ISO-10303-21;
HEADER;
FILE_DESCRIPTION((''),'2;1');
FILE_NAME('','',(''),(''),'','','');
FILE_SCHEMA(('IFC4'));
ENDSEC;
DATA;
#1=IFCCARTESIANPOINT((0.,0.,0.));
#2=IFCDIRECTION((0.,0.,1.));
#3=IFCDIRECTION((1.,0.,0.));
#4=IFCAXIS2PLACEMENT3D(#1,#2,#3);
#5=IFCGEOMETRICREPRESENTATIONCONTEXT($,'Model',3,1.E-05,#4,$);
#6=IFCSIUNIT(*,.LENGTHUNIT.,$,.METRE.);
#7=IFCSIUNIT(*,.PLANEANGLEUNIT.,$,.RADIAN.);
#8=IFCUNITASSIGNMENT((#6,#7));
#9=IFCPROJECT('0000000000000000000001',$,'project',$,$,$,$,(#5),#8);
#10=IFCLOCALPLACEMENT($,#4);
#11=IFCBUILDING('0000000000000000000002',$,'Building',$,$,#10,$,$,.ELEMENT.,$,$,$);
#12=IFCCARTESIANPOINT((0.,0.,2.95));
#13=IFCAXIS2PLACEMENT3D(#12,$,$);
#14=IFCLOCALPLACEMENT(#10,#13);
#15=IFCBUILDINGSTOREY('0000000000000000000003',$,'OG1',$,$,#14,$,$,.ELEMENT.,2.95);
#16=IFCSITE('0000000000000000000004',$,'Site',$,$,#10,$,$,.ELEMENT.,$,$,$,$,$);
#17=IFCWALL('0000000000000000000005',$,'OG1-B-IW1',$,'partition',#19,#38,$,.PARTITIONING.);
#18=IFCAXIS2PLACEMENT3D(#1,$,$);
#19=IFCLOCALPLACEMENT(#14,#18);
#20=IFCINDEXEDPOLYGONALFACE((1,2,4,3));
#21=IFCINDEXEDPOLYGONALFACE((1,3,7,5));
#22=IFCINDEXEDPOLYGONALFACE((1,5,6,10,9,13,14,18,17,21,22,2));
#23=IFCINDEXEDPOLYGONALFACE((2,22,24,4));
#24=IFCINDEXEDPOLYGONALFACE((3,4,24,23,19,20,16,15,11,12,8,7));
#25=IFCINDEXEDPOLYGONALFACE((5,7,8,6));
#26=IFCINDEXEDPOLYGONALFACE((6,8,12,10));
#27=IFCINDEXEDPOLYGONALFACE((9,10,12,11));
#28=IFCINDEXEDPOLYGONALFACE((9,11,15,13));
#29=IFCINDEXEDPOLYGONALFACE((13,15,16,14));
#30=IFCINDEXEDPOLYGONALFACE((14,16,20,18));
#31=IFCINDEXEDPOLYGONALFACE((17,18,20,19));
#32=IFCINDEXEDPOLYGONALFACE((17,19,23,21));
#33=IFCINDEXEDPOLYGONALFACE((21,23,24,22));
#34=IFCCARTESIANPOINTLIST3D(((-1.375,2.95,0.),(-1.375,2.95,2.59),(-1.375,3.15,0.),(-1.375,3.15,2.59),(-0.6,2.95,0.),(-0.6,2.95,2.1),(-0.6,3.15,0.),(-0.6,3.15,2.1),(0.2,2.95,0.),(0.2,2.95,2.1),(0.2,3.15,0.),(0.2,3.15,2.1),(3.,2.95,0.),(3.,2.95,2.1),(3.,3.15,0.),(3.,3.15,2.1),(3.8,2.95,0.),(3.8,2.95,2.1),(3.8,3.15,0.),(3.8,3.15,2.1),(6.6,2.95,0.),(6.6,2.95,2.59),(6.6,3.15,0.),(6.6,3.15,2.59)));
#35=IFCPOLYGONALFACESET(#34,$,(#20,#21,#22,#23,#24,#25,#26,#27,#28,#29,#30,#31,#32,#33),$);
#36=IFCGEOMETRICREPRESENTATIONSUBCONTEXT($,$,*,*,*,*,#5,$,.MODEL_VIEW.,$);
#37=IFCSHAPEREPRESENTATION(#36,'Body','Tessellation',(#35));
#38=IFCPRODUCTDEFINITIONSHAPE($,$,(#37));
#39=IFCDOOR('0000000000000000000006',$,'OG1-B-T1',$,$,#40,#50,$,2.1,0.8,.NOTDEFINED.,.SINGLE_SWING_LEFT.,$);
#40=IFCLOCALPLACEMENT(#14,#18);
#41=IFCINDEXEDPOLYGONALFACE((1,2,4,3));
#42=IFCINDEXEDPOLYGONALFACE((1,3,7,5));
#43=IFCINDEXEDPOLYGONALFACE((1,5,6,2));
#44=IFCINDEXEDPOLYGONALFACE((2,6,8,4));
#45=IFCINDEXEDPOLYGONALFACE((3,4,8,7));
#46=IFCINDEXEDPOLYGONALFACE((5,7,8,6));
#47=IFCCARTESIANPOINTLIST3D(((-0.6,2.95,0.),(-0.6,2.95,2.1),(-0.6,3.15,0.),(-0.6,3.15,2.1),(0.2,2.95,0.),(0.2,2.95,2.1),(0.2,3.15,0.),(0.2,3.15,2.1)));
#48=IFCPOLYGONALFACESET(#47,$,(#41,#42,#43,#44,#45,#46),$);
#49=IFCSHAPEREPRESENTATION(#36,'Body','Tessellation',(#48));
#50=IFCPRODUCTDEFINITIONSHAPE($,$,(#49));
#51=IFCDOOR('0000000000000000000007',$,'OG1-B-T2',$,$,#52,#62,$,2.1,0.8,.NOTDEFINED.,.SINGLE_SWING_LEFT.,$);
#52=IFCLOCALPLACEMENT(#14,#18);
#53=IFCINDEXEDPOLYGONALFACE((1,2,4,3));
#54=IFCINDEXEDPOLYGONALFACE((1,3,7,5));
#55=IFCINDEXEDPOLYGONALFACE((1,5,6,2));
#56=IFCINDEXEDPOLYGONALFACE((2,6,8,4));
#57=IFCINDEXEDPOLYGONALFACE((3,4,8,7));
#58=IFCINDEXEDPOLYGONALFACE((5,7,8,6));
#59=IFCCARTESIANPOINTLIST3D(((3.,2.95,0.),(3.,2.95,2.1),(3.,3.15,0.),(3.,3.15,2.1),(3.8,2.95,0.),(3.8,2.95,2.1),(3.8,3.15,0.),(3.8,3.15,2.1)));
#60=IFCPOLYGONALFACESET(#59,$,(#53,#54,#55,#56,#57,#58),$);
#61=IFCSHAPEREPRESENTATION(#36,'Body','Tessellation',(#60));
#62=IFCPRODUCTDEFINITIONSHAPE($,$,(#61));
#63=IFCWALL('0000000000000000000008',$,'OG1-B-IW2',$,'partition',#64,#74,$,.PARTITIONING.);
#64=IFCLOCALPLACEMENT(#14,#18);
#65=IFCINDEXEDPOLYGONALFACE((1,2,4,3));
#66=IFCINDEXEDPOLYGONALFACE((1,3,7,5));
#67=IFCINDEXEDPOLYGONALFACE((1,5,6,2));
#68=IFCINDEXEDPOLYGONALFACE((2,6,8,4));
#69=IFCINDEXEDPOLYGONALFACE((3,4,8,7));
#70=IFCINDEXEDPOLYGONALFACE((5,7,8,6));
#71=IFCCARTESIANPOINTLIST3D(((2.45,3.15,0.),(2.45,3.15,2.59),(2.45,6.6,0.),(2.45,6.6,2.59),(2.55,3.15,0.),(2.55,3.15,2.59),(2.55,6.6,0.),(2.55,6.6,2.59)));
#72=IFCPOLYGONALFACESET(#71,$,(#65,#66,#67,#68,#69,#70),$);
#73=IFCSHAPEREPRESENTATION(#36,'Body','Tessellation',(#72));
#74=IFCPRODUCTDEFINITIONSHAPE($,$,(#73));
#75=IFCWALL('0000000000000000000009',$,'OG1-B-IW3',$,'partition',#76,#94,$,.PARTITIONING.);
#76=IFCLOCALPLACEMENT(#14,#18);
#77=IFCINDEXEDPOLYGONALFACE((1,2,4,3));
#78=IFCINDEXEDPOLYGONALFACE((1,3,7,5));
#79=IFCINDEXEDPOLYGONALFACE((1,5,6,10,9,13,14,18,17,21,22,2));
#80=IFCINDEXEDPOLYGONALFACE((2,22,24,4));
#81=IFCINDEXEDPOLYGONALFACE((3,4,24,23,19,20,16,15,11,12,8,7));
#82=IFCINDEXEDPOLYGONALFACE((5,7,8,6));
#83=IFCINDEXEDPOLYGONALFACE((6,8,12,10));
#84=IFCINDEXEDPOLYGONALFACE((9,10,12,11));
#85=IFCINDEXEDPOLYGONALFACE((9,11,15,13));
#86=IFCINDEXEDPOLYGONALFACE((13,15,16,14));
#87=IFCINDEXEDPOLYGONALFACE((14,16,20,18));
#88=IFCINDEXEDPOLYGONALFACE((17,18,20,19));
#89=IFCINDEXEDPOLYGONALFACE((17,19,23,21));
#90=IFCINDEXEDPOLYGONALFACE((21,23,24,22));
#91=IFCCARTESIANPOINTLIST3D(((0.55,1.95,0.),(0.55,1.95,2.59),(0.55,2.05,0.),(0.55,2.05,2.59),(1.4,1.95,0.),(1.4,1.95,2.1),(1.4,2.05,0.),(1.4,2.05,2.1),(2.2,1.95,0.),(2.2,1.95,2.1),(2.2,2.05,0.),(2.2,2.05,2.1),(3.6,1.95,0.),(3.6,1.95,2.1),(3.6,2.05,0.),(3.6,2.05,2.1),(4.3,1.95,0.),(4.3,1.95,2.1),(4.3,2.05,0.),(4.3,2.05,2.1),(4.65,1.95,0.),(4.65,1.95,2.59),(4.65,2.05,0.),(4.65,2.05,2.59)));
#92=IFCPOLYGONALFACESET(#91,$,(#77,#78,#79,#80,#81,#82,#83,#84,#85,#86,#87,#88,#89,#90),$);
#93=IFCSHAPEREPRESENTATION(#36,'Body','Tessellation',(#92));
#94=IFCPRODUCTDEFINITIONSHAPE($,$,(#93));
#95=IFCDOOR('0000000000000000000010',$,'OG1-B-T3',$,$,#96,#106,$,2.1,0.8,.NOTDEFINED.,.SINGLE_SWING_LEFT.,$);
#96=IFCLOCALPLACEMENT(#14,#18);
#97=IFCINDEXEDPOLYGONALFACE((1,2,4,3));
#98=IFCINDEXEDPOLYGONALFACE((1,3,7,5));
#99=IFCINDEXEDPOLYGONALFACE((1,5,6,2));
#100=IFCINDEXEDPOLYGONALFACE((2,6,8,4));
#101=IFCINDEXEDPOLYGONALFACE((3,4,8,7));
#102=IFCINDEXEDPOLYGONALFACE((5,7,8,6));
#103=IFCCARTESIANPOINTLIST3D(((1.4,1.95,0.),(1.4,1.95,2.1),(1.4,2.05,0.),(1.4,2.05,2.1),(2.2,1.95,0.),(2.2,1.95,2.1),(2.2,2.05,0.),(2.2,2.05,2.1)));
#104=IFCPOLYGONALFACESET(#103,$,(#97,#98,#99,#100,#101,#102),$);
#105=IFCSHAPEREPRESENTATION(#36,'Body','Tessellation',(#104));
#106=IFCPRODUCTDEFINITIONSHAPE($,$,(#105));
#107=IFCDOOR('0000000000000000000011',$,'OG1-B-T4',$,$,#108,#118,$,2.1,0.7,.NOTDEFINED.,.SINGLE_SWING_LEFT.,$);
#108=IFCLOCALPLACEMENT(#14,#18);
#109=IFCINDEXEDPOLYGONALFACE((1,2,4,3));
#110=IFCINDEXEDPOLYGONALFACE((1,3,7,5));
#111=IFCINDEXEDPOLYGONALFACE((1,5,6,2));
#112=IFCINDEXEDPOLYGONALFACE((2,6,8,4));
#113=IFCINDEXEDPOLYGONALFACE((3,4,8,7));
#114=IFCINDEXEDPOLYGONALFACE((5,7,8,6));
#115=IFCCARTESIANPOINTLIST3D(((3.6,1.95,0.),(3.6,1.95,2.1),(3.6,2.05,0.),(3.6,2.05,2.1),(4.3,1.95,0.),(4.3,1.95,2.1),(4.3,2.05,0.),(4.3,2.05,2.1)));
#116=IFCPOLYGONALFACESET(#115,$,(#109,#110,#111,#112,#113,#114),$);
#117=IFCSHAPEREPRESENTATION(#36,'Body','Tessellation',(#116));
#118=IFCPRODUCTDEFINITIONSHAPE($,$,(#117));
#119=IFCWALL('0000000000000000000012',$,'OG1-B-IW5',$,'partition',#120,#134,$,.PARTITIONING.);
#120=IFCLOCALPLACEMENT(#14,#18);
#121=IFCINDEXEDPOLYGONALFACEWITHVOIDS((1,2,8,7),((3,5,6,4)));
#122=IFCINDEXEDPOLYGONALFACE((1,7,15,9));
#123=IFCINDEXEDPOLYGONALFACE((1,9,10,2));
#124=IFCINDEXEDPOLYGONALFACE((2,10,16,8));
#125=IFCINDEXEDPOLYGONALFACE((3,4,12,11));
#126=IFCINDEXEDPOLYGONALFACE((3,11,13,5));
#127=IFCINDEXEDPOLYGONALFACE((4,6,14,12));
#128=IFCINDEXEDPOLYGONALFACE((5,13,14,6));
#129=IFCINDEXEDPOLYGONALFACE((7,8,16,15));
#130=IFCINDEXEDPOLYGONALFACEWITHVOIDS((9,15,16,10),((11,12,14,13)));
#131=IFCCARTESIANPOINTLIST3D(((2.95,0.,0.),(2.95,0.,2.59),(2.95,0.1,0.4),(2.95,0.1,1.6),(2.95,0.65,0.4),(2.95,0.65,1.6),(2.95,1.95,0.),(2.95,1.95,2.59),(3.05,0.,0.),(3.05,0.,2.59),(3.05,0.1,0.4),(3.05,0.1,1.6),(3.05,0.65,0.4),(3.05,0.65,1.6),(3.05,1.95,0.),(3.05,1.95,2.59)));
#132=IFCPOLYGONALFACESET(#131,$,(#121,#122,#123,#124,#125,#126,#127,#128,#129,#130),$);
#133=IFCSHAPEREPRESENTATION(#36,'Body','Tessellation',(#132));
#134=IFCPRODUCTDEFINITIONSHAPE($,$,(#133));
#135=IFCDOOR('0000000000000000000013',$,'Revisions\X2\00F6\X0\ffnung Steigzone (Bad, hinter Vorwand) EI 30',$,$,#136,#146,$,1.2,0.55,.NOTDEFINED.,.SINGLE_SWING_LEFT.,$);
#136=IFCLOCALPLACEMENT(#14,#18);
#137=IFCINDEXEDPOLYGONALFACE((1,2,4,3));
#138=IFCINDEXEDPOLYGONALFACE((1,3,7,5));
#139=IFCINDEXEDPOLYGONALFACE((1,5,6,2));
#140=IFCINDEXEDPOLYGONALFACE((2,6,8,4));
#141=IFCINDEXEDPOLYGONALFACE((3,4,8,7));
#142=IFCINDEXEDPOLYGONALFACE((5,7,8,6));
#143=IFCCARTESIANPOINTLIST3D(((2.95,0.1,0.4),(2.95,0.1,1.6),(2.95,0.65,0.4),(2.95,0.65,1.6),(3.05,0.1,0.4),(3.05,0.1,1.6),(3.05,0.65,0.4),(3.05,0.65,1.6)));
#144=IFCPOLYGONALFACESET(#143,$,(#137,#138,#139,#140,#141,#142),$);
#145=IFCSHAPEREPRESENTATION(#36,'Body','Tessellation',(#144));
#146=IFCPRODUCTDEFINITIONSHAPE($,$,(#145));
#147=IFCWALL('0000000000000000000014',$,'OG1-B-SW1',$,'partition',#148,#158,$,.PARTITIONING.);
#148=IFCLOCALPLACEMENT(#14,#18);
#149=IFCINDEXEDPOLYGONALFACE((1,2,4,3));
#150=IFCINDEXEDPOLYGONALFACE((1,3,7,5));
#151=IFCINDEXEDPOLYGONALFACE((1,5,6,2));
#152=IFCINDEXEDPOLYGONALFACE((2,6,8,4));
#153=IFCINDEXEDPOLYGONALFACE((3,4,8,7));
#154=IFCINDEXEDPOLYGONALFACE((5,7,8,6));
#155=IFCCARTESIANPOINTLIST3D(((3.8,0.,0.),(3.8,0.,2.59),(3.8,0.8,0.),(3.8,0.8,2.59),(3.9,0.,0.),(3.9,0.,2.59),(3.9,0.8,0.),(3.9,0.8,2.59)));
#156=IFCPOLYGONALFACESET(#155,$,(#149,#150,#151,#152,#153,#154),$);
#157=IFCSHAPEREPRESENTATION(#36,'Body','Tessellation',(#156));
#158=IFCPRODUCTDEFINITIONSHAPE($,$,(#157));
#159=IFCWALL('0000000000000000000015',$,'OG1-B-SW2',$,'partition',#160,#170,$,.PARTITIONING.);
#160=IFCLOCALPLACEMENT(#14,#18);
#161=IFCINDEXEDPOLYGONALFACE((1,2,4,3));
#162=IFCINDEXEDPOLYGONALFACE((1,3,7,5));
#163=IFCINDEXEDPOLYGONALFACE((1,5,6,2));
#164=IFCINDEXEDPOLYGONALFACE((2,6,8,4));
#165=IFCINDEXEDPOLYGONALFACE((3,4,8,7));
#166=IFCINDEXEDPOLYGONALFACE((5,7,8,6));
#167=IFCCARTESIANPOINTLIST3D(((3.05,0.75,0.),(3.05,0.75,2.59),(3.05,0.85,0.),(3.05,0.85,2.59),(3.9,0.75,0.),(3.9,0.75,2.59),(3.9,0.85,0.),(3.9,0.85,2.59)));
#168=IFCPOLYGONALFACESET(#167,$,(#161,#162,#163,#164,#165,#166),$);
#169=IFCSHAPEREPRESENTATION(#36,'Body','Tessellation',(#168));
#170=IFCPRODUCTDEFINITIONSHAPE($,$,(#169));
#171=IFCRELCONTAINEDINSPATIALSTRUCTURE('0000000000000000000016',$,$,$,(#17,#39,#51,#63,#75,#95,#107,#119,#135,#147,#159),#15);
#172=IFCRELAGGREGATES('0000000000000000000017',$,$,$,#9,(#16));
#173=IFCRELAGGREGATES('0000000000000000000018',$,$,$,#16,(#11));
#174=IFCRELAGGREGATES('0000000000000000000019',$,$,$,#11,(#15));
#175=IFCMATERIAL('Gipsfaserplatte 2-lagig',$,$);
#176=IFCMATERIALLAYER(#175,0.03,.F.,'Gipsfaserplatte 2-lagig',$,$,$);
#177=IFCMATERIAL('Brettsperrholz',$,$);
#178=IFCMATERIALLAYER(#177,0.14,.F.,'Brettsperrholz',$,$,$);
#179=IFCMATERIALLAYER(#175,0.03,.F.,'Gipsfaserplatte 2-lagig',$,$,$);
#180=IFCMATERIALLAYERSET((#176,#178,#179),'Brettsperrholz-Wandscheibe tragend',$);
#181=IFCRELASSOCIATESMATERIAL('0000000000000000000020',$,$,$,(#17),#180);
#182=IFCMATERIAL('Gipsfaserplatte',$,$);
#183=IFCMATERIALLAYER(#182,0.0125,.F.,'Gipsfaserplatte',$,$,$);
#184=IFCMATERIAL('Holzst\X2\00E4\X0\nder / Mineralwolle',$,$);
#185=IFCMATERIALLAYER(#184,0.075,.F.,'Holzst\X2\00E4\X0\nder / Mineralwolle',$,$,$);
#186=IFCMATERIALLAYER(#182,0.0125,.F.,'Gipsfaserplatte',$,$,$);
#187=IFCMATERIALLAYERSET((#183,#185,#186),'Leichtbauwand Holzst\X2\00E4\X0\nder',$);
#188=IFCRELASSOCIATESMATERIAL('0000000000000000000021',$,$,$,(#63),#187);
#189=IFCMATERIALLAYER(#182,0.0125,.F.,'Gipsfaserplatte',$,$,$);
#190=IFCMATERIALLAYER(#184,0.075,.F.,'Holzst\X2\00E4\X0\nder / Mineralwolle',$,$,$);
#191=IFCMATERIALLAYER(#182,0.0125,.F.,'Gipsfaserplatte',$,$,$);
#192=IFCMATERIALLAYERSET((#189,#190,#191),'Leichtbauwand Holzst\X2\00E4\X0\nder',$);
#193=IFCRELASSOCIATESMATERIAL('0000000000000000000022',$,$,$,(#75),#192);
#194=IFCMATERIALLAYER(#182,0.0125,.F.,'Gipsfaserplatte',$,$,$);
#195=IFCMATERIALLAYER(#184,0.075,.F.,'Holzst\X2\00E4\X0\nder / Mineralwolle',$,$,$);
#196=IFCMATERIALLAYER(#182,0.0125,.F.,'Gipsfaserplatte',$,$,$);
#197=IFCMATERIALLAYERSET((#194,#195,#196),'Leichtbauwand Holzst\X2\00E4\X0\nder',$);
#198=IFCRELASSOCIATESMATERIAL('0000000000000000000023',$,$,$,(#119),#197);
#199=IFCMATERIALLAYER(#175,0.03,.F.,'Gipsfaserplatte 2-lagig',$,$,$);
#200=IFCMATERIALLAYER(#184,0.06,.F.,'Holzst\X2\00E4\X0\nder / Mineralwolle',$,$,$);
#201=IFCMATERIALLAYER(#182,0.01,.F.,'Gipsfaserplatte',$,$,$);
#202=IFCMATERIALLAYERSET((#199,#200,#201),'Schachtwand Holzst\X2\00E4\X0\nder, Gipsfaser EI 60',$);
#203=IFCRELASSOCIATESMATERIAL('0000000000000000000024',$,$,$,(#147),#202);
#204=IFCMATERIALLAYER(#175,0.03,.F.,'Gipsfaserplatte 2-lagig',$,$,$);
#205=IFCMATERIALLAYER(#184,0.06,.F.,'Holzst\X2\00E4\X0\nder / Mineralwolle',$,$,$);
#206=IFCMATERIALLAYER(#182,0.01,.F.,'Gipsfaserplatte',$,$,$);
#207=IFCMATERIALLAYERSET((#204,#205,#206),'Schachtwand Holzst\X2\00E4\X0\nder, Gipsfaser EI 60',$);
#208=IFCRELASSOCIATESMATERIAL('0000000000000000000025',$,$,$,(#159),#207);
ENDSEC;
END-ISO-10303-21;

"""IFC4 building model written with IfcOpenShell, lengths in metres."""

from ifc_helpers import new_model, si_unit, frame, frame_2d, origin, origin_with_axes, place, context, subcontext, project, spatial, rectangle, extrude, material, layer, layer_set, element, fill, save


model = new_model("IFC4")

# Units and contexts
model_context = context("Model", 3, precision=1e-05, world=origin_with_axes())
sub_context = subcontext(model_context, None, None, "MODEL_VIEW")
ifc_project = project(units=[si_unit("LENGTHUNIT", "METRE"), si_unit("PLANEANGLEUNIT", "RADIAN")], contexts=[model_context])

# Site, building, storey
placement = place(None, origin_with_axes())
site = spatial("IfcSite", under=ifc_project, at=placement, Name="Site", CompositionType="ELEMENT")
building = spatial("IfcBuilding", under=site, at=placement, Name="Building", CompositionType="ELEMENT")
storey_placement = place(placement, frame((0.0, 0.0, 2.95)))
storey = spatial("IfcBuildingStorey", under=building, at=storey_placement, Name="OG1", CompositionType="ELEMENT", Elevation=2.95)

# Shared definitions
ifc_material_1 = material(Name="Gipsfaserplatte")

# Wall, openings, doors
ifc_material_2 = material(Name="Gipsfaserplatte 2-lagig")
ifc_layer_1 = layer(ifc_material_2, 0.03, ventilated=False, Name="Gipsfaserplatte 2-lagig")
ifc_material_3 = material(Name="Brettsperrholz")
ifc_layer_2 = layer(ifc_material_3, 0.14, ventilated=False, Name="Brettsperrholz")
ifc_layer_3 = layer(ifc_material_2, 0.03, ventilated=False, Name="Gipsfaserplatte 2-lagig")
ifc_layer_set_1 = layer_set([ifc_layer_1, ifc_layer_2, ifc_layer_3], Name="Brettsperrholz-Wandscheibe tragend")
wall_1_placement = place(storey_placement, frame((-1.375, 3.05, 0.0), z_axis=(0.0, 0.0, 1.0), x_axis=(1.0, 0.0, 0.0)))
wall_1 = element("IfcWall", 1, at=wall_1_placement, inside=storey, material=ifc_layer_set_1, Name="OG1-B-IW1", ObjectType="partition", PredefinedType="PARTITIONING", context=sub_context, shape_type="SweptSolid", body=[
    extrude(rectangle(XDim=7.975, YDim=0.2, at=frame_2d((3.9875, 0.0))), origin(), (0.0, 0.0, 1.0), 2.59),
])
opening_1_placement = place(wall_1_placement, frame((1.175, 0.15, 0.0), z_axis=(0.0, -1.0, 0.0), x_axis=(1.0, 0.0, 0.0)))
opening_1 = element("IfcOpeningElement", 2, at=opening_1_placement, cuts=wall_1, PredefinedType="OPENING", context=sub_context, shape_type="SweptSolid", body=[
    extrude(rectangle(XDim=0.8, YDim=2.1, at=frame_2d((0.0, 1.05))), origin(), (0.0, 0.0, 1.0), 0.3),
])
opening_2_placement = place(wall_1_placement, frame((4.775, 0.15, 0.0), z_axis=(0.0, -1.0, 0.0), x_axis=(1.0, 0.0, 0.0)))
opening_2 = element("IfcOpeningElement", 3, at=opening_2_placement, cuts=wall_1, PredefinedType="OPENING", context=sub_context, shape_type="SweptSolid", body=[
    extrude(rectangle(XDim=0.8, YDim=2.1, at=frame_2d((0.0, 1.05))), origin(), (0.0, 0.0, 1.0), 0.3),
])
door_1_placement = place(wall_1_placement, frame((1.175, 0.1, 0.0), z_axis=(0.0, -1.0, 0.0), x_axis=(1.0, 0.0, 0.0)))
door_1 = element("IfcDoor", 4, at=door_1_placement, inside=storey, Name="OG1-B-T1", OperationType="SINGLE_SWING_LEFT", OverallHeight=2.1, OverallWidth=0.8, PredefinedType="NOTDEFINED", context=sub_context, shape_type="SweptSolid", body=[
    extrude(rectangle(XDim=0.8, YDim=2.1, at=frame_2d((0.0, 1.05))), origin(), (0.0, 0.0, 1.0), 0.2),
])
fill(opening_1, door_1)
door_2_placement = place(wall_1_placement, frame((4.775, 0.1, 0.0), z_axis=(0.0, -1.0, 0.0), x_axis=(1.0, 0.0, 0.0)))
door_2 = element("IfcDoor", 5, at=door_2_placement, inside=storey, Name="OG1-B-T2", OperationType="SINGLE_SWING_LEFT", OverallHeight=2.1, OverallWidth=0.8, PredefinedType="NOTDEFINED", context=sub_context, shape_type="SweptSolid", body=[
    extrude(rectangle(XDim=0.8, YDim=2.1, at=frame_2d((0.0, 1.05))), origin(), (0.0, 0.0, 1.0), 0.2),
])
fill(opening_2, door_2)

# Wall
ifc_layer_4 = layer(ifc_material_1, 0.0125, ventilated=False, Name="Gipsfaserplatte")
ifc_material_4 = material(Name="Holzständer / Mineralwolle")
ifc_layer_5 = layer(ifc_material_4, 0.075, ventilated=False, Name="Holzständer / Mineralwolle")
ifc_layer_6 = layer(ifc_material_1, 0.0125, ventilated=False, Name="Gipsfaserplatte")
ifc_layer_set_2 = layer_set([ifc_layer_4, ifc_layer_5, ifc_layer_6], Name="Leichtbauwand Holzständer")
wall_2_placement = place(storey_placement, frame((2.5, 3.15, 0.0), z_axis=(0.0, 0.0, 1.0), x_axis=(0.0, 1.0, 0.0)))
element("IfcWall", 6, at=wall_2_placement, inside=storey, material=ifc_layer_set_2, Name="OG1-B-IW2", ObjectType="partition", PredefinedType="PARTITIONING", context=sub_context, shape_type="SweptSolid", body=[
    extrude(rectangle(XDim=3.45, YDim=0.1, at=frame_2d((1.725, 0.0))), origin(), (0.0, 0.0, 1.0), 2.59),
])

# Wall, openings, doors
ifc_layer_7 = layer(ifc_material_1, 0.0125, ventilated=False, Name="Gipsfaserplatte")
ifc_layer_8 = layer(ifc_material_4, 0.075, ventilated=False, Name="Holzständer / Mineralwolle")
ifc_layer_9 = layer(ifc_material_1, 0.0125, ventilated=False, Name="Gipsfaserplatte")
ifc_layer_set_3 = layer_set([ifc_layer_7, ifc_layer_8, ifc_layer_9], Name="Leichtbauwand Holzständer")
wall_3_placement = place(storey_placement, frame((0.55, 2.0, 0.0), z_axis=(0.0, 0.0, 1.0), x_axis=(1.0, 0.0, 0.0)))
wall_3 = element("IfcWall", 7, at=wall_3_placement, inside=storey, material=ifc_layer_set_3, Name="OG1-B-IW3", ObjectType="partition", PredefinedType="PARTITIONING", context=sub_context, shape_type="SweptSolid", body=[
    extrude(rectangle(XDim=4.1, YDim=0.1, at=frame_2d((2.05, 0.0))), origin(), (0.0, 0.0, 1.0), 2.59),
])
opening_3_placement = place(wall_3_placement, frame((1.25, 0.1, 0.0), z_axis=(0.0, -1.0, 0.0), x_axis=(1.0, 0.0, 0.0)))
opening_3 = element("IfcOpeningElement", 8, at=opening_3_placement, cuts=wall_3, PredefinedType="OPENING", context=sub_context, shape_type="SweptSolid", body=[
    extrude(rectangle(XDim=0.8, YDim=2.1, at=frame_2d((0.0, 1.05))), origin(), (0.0, 0.0, 1.0), 0.2),
])
opening_4_placement = place(wall_3_placement, frame((3.4, 0.1, 0.0), z_axis=(0.0, -1.0, 0.0), x_axis=(1.0, 0.0, 0.0)))
opening_4 = element("IfcOpeningElement", 9, at=opening_4_placement, cuts=wall_3, PredefinedType="OPENING", context=sub_context, shape_type="SweptSolid", body=[
    extrude(rectangle(XDim=0.7, YDim=2.1, at=frame_2d((0.0, 1.05))), origin(), (0.0, 0.0, 1.0), 0.2),
])
door_3_placement = place(wall_3_placement, frame((1.25, 0.05, 0.0), z_axis=(0.0, -1.0, 0.0), x_axis=(1.0, 0.0, 0.0)))
door_3 = element("IfcDoor", 10, at=door_3_placement, inside=storey, Name="OG1-B-T3", OperationType="SINGLE_SWING_LEFT", OverallHeight=2.1, OverallWidth=0.8, PredefinedType="NOTDEFINED", context=sub_context, shape_type="SweptSolid", body=[
    extrude(rectangle(XDim=0.8, YDim=2.1, at=frame_2d((0.0, 1.05))), origin(), (0.0, 0.0, 1.0), 0.1),
])
fill(opening_3, door_3)
door_4_placement = place(wall_3_placement, frame((3.4, 0.05, 0.0), z_axis=(0.0, -1.0, 0.0), x_axis=(1.0, 0.0, 0.0)))
door_4 = element("IfcDoor", 11, at=door_4_placement, inside=storey, Name="OG1-B-T4", OperationType="SINGLE_SWING_LEFT", OverallHeight=2.1, OverallWidth=0.7, PredefinedType="NOTDEFINED", context=sub_context, shape_type="SweptSolid", body=[
    extrude(rectangle(XDim=0.7, YDim=2.1, at=frame_2d((0.0, 1.05))), origin(), (0.0, 0.0, 1.0), 0.1),
])
fill(opening_4, door_4)

# Wall, opening, door
ifc_layer_10 = layer(ifc_material_1, 0.0125, ventilated=False, Name="Gipsfaserplatte")
ifc_layer_11 = layer(ifc_material_4, 0.075, ventilated=False, Name="Holzständer / Mineralwolle")
ifc_layer_12 = layer(ifc_material_1, 0.0125, ventilated=False, Name="Gipsfaserplatte")
ifc_layer_set_4 = layer_set([ifc_layer_10, ifc_layer_11, ifc_layer_12], Name="Leichtbauwand Holzständer")
wall_4_placement = place(storey_placement, frame((3.0, 0.0, 0.0), z_axis=(0.0, 0.0, 1.0), x_axis=(0.0, 1.0, 0.0)))
wall_4 = element("IfcWall", 12, at=wall_4_placement, inside=storey, material=ifc_layer_set_4, Name="OG1-B-IW5", ObjectType="partition", PredefinedType="PARTITIONING", context=sub_context, shape_type="SweptSolid", body=[
    extrude(rectangle(XDim=1.95, YDim=0.1, at=frame_2d((0.975, 0.0))), origin(), (0.0, 0.0, 1.0), 2.59),
])
opening_5_placement = place(wall_4_placement, frame((0.375, 0.1, 0.4), z_axis=(0.0, -1.0, 0.0), x_axis=(1.0, 0.0, 0.0)))
opening_5 = element("IfcOpeningElement", 13, at=opening_5_placement, cuts=wall_4, PredefinedType="OPENING", context=sub_context, shape_type="SweptSolid", body=[
    extrude(rectangle(XDim=0.55, YDim=1.2, at=frame_2d((0.0, 0.6))), origin(), (0.0, 0.0, 1.0), 0.2),
])
door_5_placement = place(wall_4_placement, frame((0.375, 0.05, 0.4), z_axis=(0.0, -1.0, 0.0), x_axis=(1.0, 0.0, 0.0)))
door_5 = element("IfcDoor", 14, at=door_5_placement, inside=storey, Name="Revisionsöffnung Steigzone (Bad, hinter Vorwand) EI 30", OperationType="SINGLE_SWING_LEFT", OverallHeight=1.2, OverallWidth=0.55, PredefinedType="NOTDEFINED", context=sub_context, shape_type="SweptSolid", body=[
    extrude(rectangle(XDim=0.55, YDim=1.2, at=frame_2d((0.0, 0.6))), origin(), (0.0, 0.0, 1.0), 0.1),
])
fill(opening_5, door_5)

# Walls
ifc_layer_13 = layer(ifc_material_2, 0.03, ventilated=False, Name="Gipsfaserplatte 2-lagig")
ifc_layer_14 = layer(ifc_material_4, 0.06, ventilated=False, Name="Holzständer / Mineralwolle")
ifc_layer_15 = layer(ifc_material_1, 0.01, ventilated=False, Name="Gipsfaserplatte")
ifc_layer_set_5 = layer_set([ifc_layer_13, ifc_layer_14, ifc_layer_15], Name="Schachtwand Holzständer, Gipsfaser EI 60")
wall_5_placement = place(storey_placement, frame((3.85, 0.0, 0.0), z_axis=(0.0, 0.0, 1.0), x_axis=(0.0, 1.0, 0.0)))
element("IfcWall", 15, at=wall_5_placement, inside=storey, material=ifc_layer_set_5, Name="OG1-B-SW1", ObjectType="partition", PredefinedType="PARTITIONING", context=sub_context, shape_type="SweptSolid", body=[
    extrude(rectangle(XDim=0.8, YDim=0.1, at=frame_2d((0.4, 0.0))), origin(), (0.0, 0.0, 1.0), 2.59),
])
ifc_layer_16 = layer(ifc_material_2, 0.03, ventilated=False, Name="Gipsfaserplatte 2-lagig")
ifc_layer_17 = layer(ifc_material_4, 0.06, ventilated=False, Name="Holzständer / Mineralwolle")
ifc_layer_18 = layer(ifc_material_1, 0.01, ventilated=False, Name="Gipsfaserplatte")
ifc_layer_set_6 = layer_set([ifc_layer_16, ifc_layer_17, ifc_layer_18], Name="Schachtwand Holzständer, Gipsfaser EI 60")
wall_6_placement = place(storey_placement, frame((3.05, 0.8, 0.0), z_axis=(0.0, 0.0, 1.0), x_axis=(1.0, 0.0, 0.0)))
element("IfcWall", 16, at=wall_6_placement, inside=storey, material=ifc_layer_set_6, Name="OG1-B-SW2", ObjectType="partition", PredefinedType="PARTITIONING", context=sub_context, shape_type="SweptSolid", body=[
    extrude(rectangle(XDim=0.85, YDim=0.1, at=frame_2d((0.425, 0.0))), origin(), (0.0, 0.0, 1.0), 2.59),
])

save(model, "model.ifc")
